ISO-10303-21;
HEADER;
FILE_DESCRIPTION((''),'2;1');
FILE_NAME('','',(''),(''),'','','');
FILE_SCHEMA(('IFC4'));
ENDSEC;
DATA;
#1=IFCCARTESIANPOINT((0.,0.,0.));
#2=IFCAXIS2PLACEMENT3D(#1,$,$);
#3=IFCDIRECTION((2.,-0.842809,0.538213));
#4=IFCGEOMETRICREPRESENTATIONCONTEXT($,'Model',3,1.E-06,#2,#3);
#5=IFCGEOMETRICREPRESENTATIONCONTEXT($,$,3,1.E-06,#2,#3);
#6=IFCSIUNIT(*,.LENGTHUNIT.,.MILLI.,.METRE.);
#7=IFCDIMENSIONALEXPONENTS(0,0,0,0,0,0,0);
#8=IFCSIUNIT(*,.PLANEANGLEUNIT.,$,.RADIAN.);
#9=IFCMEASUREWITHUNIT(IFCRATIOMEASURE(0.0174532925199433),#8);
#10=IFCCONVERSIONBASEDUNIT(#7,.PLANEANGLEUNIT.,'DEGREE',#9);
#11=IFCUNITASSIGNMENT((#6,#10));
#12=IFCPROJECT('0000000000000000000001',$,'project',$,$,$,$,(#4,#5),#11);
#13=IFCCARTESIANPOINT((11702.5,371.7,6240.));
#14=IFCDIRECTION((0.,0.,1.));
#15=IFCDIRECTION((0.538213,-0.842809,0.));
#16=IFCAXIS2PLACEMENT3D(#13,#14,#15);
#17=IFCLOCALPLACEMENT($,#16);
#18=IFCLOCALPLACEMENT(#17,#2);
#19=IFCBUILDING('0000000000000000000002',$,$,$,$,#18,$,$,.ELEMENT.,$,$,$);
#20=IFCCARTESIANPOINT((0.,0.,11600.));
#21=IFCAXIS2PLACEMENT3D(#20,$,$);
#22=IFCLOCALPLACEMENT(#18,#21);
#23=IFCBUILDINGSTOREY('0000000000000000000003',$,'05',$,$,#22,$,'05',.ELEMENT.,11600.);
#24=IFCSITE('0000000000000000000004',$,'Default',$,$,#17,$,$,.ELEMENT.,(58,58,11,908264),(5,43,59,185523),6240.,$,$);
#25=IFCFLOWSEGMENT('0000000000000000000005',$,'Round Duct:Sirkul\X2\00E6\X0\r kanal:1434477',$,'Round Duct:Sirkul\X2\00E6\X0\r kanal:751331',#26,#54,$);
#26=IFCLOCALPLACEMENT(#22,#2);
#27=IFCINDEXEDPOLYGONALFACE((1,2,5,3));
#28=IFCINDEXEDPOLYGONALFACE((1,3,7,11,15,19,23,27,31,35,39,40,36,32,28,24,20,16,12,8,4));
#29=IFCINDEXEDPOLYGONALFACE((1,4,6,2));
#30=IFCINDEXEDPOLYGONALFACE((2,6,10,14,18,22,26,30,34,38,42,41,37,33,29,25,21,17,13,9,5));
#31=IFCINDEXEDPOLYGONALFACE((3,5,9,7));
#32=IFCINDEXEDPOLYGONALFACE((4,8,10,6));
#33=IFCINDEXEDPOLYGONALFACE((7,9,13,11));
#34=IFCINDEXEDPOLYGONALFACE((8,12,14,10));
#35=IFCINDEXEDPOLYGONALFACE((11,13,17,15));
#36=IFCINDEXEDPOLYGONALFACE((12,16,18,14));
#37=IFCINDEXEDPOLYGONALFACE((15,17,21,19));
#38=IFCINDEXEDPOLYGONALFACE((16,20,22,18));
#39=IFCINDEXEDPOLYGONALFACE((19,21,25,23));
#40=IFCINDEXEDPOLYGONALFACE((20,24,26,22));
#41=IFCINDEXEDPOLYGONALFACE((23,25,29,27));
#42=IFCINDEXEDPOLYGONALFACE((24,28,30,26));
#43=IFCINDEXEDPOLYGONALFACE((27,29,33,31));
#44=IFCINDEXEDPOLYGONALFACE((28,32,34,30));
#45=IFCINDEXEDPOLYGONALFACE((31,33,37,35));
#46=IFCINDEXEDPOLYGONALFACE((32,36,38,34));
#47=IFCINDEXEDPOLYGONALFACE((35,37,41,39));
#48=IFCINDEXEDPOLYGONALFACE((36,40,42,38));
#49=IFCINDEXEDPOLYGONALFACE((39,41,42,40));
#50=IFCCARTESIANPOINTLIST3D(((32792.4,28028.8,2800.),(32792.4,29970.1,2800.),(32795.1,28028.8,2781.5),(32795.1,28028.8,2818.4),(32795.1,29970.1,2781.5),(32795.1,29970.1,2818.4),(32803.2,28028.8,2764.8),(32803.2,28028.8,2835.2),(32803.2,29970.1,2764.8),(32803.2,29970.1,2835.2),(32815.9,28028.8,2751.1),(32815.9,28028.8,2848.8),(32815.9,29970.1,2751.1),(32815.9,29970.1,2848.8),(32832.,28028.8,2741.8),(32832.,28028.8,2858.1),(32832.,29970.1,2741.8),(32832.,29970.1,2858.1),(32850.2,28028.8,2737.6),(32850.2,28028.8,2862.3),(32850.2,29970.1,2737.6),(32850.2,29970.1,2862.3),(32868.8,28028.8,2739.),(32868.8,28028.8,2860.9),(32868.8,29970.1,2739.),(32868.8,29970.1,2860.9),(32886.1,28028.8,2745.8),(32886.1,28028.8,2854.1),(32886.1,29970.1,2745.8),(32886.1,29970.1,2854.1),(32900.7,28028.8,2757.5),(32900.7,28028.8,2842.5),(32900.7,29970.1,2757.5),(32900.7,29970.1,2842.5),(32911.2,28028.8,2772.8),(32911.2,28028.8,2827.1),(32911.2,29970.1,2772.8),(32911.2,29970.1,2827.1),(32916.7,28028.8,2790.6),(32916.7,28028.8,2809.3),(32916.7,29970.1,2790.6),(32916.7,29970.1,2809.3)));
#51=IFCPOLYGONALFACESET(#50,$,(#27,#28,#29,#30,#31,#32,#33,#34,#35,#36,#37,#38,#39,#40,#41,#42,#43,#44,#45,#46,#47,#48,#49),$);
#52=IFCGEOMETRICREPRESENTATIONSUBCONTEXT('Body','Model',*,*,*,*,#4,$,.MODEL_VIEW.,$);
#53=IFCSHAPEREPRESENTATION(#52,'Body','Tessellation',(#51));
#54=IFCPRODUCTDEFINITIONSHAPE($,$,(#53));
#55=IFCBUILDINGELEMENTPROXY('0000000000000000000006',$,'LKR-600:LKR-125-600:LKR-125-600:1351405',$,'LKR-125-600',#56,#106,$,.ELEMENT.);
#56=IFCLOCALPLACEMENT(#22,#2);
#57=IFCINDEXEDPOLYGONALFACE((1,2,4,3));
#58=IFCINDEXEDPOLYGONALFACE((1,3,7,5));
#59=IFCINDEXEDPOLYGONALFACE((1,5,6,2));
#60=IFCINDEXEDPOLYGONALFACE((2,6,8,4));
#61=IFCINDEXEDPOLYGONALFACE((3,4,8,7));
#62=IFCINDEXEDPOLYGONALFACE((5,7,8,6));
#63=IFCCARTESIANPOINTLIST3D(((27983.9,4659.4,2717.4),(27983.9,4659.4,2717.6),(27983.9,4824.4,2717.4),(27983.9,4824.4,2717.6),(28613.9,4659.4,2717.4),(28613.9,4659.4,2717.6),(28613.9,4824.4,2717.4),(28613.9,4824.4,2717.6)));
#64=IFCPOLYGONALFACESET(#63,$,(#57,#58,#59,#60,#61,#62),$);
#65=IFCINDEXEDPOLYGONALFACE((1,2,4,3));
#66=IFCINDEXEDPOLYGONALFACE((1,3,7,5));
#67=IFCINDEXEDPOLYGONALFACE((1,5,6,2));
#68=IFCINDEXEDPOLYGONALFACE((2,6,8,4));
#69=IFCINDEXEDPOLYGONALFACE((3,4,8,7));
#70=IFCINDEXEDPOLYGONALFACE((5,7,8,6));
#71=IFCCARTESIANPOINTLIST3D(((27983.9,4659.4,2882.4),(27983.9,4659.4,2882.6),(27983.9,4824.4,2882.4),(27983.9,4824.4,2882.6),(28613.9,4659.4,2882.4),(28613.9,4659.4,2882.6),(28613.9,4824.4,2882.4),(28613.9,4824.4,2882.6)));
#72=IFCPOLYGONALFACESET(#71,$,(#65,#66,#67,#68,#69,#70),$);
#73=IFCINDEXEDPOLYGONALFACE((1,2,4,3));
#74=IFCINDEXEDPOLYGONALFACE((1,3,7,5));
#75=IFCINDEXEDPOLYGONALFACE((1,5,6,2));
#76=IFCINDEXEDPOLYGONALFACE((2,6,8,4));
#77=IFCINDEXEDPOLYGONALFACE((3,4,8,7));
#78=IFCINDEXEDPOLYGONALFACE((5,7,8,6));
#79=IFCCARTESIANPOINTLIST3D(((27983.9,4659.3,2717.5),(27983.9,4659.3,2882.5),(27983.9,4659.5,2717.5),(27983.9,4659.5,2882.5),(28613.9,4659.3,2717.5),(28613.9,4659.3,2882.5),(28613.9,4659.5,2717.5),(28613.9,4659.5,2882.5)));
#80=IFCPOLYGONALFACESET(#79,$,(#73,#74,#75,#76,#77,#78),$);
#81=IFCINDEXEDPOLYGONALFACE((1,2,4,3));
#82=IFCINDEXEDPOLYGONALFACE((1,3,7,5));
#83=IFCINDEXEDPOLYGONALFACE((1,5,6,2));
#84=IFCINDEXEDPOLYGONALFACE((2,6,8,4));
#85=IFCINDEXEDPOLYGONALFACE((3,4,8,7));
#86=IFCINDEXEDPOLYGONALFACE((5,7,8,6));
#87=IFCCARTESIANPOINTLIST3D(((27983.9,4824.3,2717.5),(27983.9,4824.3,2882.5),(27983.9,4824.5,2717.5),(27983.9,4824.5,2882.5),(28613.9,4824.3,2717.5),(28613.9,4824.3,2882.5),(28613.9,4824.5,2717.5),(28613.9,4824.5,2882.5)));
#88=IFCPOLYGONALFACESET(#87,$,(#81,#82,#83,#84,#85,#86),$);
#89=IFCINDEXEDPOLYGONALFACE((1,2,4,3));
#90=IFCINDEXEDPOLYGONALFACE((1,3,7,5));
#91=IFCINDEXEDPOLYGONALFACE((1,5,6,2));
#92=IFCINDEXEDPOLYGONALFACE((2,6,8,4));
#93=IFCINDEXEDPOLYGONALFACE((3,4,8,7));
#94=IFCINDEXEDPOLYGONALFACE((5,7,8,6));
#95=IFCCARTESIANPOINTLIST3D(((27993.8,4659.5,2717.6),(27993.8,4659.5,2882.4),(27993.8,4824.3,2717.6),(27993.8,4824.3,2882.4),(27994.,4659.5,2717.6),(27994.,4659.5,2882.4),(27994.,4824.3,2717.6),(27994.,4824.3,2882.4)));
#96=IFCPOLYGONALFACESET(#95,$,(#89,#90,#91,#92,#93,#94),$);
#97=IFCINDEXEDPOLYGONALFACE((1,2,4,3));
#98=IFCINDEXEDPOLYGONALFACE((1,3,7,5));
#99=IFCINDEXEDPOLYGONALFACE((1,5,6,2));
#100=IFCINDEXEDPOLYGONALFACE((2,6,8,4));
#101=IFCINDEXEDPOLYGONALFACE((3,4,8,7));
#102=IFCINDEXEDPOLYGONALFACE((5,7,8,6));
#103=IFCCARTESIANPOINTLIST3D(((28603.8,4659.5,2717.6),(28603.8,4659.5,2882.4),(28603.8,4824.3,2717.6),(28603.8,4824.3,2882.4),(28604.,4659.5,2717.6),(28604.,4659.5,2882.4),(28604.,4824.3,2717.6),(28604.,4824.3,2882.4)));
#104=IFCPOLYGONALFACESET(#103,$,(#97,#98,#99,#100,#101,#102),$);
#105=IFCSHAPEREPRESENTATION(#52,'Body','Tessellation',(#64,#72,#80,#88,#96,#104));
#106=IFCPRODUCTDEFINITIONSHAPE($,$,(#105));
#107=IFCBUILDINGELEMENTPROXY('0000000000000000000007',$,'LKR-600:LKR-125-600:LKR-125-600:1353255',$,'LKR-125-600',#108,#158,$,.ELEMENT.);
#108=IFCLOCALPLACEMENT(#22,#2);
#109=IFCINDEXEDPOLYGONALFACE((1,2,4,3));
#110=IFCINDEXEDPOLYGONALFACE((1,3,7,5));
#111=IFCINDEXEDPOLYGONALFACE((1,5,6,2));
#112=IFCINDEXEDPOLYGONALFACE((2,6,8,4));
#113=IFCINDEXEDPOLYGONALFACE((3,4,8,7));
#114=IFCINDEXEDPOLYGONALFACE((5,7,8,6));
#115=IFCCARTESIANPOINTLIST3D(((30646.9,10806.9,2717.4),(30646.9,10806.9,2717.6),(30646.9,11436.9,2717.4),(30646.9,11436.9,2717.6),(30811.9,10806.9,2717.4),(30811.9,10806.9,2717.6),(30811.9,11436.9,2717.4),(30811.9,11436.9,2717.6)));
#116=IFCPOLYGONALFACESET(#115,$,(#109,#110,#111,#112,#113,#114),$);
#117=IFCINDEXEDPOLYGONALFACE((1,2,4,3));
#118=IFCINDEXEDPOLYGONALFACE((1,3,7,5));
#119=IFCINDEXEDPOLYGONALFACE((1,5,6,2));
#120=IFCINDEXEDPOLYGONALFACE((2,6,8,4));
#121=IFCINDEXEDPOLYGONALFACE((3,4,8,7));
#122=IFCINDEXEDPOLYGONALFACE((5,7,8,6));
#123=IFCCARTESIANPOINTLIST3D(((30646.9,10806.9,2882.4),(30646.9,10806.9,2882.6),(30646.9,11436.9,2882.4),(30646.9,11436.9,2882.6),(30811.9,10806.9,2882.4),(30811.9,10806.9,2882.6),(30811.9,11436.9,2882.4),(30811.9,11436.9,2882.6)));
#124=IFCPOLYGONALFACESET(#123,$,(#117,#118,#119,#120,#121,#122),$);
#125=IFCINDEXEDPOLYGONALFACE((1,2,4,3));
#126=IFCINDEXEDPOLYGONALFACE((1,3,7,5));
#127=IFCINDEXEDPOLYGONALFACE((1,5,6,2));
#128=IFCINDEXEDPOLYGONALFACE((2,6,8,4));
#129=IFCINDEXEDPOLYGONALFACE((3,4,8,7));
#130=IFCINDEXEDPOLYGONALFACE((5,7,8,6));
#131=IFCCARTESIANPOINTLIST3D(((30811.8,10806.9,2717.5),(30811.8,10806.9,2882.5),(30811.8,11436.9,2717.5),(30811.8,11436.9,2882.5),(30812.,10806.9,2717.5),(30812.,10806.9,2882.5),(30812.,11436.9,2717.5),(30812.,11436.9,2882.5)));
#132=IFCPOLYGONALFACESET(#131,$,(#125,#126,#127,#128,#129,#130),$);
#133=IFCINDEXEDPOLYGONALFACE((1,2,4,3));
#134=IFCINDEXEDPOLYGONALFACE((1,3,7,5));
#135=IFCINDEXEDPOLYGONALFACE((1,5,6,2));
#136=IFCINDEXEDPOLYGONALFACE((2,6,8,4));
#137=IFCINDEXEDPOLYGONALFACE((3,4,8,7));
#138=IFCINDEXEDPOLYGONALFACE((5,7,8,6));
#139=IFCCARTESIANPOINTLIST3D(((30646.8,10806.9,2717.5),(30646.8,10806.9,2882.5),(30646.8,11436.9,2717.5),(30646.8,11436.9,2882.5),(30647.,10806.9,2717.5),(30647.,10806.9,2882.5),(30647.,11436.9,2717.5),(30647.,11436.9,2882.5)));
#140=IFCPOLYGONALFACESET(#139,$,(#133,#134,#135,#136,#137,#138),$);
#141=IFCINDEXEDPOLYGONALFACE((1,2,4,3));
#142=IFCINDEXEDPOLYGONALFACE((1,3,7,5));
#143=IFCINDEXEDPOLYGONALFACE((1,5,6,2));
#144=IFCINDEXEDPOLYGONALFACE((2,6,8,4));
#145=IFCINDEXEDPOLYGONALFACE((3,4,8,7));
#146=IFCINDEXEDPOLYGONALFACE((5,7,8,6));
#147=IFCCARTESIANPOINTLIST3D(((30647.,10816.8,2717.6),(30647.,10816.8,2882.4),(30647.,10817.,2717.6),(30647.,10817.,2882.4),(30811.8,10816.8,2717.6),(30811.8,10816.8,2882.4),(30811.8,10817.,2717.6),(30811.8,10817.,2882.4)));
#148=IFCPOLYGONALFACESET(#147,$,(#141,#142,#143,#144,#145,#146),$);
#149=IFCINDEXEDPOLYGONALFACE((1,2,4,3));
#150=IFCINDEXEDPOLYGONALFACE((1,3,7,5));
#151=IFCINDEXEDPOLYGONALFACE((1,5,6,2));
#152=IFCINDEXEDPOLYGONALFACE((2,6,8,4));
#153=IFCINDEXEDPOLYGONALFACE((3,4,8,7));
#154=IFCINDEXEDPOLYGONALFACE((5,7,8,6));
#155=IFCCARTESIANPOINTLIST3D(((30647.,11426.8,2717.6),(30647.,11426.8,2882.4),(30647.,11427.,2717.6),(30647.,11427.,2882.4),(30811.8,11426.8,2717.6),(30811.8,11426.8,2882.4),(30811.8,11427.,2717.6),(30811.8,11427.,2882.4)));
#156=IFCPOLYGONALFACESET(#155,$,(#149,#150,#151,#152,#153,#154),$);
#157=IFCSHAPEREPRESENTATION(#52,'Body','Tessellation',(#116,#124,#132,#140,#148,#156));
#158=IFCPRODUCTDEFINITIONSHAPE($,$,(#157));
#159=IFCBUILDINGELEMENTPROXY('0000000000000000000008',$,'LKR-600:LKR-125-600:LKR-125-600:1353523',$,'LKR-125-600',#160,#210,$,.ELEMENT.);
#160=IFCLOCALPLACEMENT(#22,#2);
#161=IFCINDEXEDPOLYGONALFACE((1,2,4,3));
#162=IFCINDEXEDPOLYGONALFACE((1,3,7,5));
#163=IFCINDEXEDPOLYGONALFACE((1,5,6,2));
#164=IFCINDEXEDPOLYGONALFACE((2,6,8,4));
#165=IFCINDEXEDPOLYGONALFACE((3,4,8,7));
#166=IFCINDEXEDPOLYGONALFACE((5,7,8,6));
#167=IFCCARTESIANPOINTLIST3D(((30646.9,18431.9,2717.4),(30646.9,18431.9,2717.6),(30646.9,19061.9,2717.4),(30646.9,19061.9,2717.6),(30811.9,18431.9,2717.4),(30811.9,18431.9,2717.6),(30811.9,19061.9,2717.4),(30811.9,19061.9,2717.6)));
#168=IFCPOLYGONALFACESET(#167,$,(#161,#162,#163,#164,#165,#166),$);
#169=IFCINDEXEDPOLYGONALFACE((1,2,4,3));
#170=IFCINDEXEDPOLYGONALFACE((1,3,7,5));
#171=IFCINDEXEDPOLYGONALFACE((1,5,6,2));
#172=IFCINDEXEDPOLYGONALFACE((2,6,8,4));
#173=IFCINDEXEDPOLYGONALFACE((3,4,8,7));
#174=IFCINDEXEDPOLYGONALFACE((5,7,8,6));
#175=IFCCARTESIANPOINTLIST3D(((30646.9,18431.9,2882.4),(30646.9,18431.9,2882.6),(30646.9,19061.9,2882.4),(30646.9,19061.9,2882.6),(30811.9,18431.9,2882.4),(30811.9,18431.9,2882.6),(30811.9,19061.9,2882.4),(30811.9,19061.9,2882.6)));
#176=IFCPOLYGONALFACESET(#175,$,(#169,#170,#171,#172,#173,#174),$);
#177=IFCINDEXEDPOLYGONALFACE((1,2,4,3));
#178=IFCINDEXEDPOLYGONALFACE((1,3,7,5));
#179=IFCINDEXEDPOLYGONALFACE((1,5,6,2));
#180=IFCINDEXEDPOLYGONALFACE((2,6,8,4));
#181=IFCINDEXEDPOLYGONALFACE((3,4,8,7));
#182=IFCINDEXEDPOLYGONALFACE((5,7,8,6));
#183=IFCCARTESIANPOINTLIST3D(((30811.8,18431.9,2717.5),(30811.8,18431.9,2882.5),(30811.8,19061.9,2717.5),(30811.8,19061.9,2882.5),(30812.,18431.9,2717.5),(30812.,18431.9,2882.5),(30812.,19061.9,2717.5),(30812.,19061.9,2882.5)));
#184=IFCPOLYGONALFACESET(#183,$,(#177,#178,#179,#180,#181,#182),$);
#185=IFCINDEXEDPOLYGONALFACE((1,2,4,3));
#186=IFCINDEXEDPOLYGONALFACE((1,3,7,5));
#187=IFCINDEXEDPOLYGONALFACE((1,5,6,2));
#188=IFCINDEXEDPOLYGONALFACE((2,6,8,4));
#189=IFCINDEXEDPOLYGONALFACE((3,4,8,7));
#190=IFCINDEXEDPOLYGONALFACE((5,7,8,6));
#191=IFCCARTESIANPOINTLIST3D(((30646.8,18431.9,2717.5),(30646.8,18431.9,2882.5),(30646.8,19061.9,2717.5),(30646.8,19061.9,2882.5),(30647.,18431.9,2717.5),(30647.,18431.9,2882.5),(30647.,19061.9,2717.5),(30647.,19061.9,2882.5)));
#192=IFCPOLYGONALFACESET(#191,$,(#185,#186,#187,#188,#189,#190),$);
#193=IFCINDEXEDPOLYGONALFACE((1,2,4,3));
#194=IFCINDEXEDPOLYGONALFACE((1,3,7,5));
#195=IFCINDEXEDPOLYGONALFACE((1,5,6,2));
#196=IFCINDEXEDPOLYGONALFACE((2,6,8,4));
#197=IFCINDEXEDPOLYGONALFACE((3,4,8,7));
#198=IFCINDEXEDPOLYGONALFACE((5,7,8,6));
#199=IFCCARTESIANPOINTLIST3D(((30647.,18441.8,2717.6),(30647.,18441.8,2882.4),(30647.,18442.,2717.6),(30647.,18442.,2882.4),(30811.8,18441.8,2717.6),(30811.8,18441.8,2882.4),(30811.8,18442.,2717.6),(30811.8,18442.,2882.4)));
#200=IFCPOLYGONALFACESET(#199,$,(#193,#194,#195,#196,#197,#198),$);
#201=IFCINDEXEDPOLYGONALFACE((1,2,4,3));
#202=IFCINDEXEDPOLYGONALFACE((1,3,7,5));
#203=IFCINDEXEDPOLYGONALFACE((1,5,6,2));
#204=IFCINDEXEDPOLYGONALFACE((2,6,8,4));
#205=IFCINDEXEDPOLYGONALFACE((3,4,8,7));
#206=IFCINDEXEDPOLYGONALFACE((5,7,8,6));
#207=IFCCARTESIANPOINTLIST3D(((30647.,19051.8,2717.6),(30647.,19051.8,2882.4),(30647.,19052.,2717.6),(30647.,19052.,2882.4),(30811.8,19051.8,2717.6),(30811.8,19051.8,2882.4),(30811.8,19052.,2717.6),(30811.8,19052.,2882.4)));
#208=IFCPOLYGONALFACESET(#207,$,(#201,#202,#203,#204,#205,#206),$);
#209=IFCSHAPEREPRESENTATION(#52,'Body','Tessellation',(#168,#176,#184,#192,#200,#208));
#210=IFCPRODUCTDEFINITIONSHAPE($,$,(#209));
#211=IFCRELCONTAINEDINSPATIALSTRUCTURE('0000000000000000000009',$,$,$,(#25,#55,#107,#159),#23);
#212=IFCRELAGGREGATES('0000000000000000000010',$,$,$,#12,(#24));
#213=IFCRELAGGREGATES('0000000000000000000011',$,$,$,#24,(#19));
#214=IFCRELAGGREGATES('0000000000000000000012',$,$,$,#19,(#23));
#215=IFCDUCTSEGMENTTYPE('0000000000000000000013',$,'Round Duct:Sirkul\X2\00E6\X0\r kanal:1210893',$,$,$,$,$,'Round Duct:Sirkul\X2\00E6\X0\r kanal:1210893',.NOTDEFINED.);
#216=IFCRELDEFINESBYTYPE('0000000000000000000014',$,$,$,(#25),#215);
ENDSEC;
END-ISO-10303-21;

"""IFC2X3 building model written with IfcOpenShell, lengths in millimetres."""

from ifc_helpers import new_model, entity, si_unit, converted_unit, direction, frame, frame_2d, origin, origin_2d_with_axis, place, context, subcontext, project, spatial, rectangle, circle, extrude, source, transform, mapped, type_object, element, save


model = new_model("IFC2X3")

# Units and contexts
model_context = context("Model", 3, precision=1e-06, world=origin(), true_north=direction((2.0, -0.842809, 0.538213)))
context_of_model = context(None, 3, precision=1e-06, world=origin(), true_north=direction((2.0, -0.842809, 0.538213)))
body_context = subcontext(model_context, "Body", "Model", "MODEL_VIEW")
ifc_project = project(units=[si_unit("LENGTHUNIT", "METRE", prefix="MILLI"), converted_unit("PLANEANGLEUNIT", "DEGREE", entity("IfcRatioMeasure", 0.0174532925199433), si_unit("PLANEANGLEUNIT", "RADIAN"), dimensions=[0, 0, 0, 0, 0, 0, 0])], contexts=[model_context, context_of_model])

# Site, building, storey
site_placement = place(None, frame((11702.5, 371.7, 6240.0), z_axis=(0.0, 0.0, 1.0), x_axis=(0.538213, -0.842809, 0.0)))
site = spatial("IfcSite", under=ifc_project, at=site_placement, Name="Default", CompositionType="ELEMENT", RefLatitude=(58, 58, 11, 908264), RefLongitude=(5, 43, 59, 185523), RefElevation=6240.0)
building_placement = place(site_placement, origin())
building = spatial("IfcBuilding", under=site, at=building_placement, CompositionType="ELEMENT")
storey_placement = place(building_placement, frame((0.0, 0.0, 11600.0)))
storey = spatial("IfcBuildingStorey", under=building, at=storey_placement, Name="05", LongName="05", CompositionType="ELEMENT", Elevation=11600.0)

# Flow segment
duct_segment_type = type_object("IfcDuctSegmentType", Name="Round Duct:Sirkulær kanal:1210893", ElementType="Round Duct:Sirkulær kanal:1210893", PredefinedType="NOTDEFINED")
flow_segment_1_placement = place(storey_placement, origin())
element("IfcFlowSegment", 1, at=flow_segment_1_placement, inside=storey, type_object=duct_segment_type, Name="Round Duct:Sirkulær kanal:1434477", ObjectType="Round Duct:Sirkulær kanal:751331", context=body_context, shape_type="SweptSolid", body=[
    extrude(circle(Radius=62.5, at=origin_2d_with_axis()), frame((32854.9, 28028.8, 2800.0), z_axis=(0.0, 1.0, 0.0), x_axis=(-1.0, 0.0, 0.0)), (0.0, 0.0, 1.0), 1941.3),
])

# Building element proxies
shared_shape_1 = source(origin(), body_context, "Body", "SweptSolid", [
    extrude(rectangle(XDim=165.0, YDim=630.0, at=frame_2d((0.0, 0.0), x_axis=(1.0, 0.0))), frame((0.0, 0.0, -82.6), z_axis=(0.0, 0.0, 1.0), x_axis=(0.0, -1.0, 0.0)), (0.0, 0.0, 1.0), 0.2),
    extrude(rectangle(XDim=165.0, YDim=630.0, at=frame_2d((0.0, 0.0), x_axis=(1.0, 0.0))), frame((0.0, 0.0, 82.4), z_axis=(0.0, 0.0, 1.0), x_axis=(0.0, -1.0, 0.0)), (0.0, 0.0, 1.0), 0.2),
    extrude(rectangle(XDim=0.2, YDim=630.0, at=frame_2d((0.0, 0.0), x_axis=(1.0, 0.0))), frame((0.0, 82.5, -82.5), z_axis=(0.0, 0.0, 1.0), x_axis=(0.0, 1.0, 0.0)), (0.0, 0.0, 1.0), 165.0),
    extrude(rectangle(XDim=0.2, YDim=630.0, at=frame_2d((0.0, 0.0), x_axis=(1.0, 0.0))), frame((0.0, -82.5, -82.5), z_axis=(0.0, 0.0, 1.0), x_axis=(0.0, 1.0, 0.0)), (0.0, 0.0, 1.0), 165.0),
    extrude(rectangle(XDim=0.2, YDim=164.8, at=frame_2d((0.0, 0.0), x_axis=(1.0, 0.0))), frame((305.0, 0.0, -82.4)), (0.0, 0.0, 1.0), 164.8),
    extrude(rectangle(XDim=0.2, YDim=164.8, at=frame_2d((0.0, 0.0), x_axis=(1.0, 0.0))), frame((-305.0, 0.0, -82.4)), (0.0, 0.0, 1.0), 164.8),
])
for number, where, z_axis, x_axis, name in (
    (2, (28298.9, 4741.9, 2800.0), (0.0, 0.0, 1.0), (-1.0, 0.0, 0.0), "LKR-600:LKR-125-600:LKR-125-600:1351405"),
    (3, (30729.4, 11121.9, 2800.0), (0.0, 0.0, 1.0), (0.0, -1.0, 0.0), "LKR-600:LKR-125-600:LKR-125-600:1353255"),
    (4, (30729.4, 18746.9, 2800.0), (0.0, 0.0, 1.0), (0.0, -1.0, 0.0), "LKR-600:LKR-125-600:LKR-125-600:1353523"),
):
    element("IfcBuildingElementProxy", number, at=place(storey_placement, frame(where, z_axis=z_axis, x_axis=x_axis)), inside=storey, Name=name, ObjectType="LKR-125-600", CompositionType="ELEMENT", context=body_context, shape_type="MappedRepresentation", body=[
        mapped(shared_shape_1, transform((0.0, 0.0, 0.0), scale=1.0)),
    ])

save(model, "model.ifc")
